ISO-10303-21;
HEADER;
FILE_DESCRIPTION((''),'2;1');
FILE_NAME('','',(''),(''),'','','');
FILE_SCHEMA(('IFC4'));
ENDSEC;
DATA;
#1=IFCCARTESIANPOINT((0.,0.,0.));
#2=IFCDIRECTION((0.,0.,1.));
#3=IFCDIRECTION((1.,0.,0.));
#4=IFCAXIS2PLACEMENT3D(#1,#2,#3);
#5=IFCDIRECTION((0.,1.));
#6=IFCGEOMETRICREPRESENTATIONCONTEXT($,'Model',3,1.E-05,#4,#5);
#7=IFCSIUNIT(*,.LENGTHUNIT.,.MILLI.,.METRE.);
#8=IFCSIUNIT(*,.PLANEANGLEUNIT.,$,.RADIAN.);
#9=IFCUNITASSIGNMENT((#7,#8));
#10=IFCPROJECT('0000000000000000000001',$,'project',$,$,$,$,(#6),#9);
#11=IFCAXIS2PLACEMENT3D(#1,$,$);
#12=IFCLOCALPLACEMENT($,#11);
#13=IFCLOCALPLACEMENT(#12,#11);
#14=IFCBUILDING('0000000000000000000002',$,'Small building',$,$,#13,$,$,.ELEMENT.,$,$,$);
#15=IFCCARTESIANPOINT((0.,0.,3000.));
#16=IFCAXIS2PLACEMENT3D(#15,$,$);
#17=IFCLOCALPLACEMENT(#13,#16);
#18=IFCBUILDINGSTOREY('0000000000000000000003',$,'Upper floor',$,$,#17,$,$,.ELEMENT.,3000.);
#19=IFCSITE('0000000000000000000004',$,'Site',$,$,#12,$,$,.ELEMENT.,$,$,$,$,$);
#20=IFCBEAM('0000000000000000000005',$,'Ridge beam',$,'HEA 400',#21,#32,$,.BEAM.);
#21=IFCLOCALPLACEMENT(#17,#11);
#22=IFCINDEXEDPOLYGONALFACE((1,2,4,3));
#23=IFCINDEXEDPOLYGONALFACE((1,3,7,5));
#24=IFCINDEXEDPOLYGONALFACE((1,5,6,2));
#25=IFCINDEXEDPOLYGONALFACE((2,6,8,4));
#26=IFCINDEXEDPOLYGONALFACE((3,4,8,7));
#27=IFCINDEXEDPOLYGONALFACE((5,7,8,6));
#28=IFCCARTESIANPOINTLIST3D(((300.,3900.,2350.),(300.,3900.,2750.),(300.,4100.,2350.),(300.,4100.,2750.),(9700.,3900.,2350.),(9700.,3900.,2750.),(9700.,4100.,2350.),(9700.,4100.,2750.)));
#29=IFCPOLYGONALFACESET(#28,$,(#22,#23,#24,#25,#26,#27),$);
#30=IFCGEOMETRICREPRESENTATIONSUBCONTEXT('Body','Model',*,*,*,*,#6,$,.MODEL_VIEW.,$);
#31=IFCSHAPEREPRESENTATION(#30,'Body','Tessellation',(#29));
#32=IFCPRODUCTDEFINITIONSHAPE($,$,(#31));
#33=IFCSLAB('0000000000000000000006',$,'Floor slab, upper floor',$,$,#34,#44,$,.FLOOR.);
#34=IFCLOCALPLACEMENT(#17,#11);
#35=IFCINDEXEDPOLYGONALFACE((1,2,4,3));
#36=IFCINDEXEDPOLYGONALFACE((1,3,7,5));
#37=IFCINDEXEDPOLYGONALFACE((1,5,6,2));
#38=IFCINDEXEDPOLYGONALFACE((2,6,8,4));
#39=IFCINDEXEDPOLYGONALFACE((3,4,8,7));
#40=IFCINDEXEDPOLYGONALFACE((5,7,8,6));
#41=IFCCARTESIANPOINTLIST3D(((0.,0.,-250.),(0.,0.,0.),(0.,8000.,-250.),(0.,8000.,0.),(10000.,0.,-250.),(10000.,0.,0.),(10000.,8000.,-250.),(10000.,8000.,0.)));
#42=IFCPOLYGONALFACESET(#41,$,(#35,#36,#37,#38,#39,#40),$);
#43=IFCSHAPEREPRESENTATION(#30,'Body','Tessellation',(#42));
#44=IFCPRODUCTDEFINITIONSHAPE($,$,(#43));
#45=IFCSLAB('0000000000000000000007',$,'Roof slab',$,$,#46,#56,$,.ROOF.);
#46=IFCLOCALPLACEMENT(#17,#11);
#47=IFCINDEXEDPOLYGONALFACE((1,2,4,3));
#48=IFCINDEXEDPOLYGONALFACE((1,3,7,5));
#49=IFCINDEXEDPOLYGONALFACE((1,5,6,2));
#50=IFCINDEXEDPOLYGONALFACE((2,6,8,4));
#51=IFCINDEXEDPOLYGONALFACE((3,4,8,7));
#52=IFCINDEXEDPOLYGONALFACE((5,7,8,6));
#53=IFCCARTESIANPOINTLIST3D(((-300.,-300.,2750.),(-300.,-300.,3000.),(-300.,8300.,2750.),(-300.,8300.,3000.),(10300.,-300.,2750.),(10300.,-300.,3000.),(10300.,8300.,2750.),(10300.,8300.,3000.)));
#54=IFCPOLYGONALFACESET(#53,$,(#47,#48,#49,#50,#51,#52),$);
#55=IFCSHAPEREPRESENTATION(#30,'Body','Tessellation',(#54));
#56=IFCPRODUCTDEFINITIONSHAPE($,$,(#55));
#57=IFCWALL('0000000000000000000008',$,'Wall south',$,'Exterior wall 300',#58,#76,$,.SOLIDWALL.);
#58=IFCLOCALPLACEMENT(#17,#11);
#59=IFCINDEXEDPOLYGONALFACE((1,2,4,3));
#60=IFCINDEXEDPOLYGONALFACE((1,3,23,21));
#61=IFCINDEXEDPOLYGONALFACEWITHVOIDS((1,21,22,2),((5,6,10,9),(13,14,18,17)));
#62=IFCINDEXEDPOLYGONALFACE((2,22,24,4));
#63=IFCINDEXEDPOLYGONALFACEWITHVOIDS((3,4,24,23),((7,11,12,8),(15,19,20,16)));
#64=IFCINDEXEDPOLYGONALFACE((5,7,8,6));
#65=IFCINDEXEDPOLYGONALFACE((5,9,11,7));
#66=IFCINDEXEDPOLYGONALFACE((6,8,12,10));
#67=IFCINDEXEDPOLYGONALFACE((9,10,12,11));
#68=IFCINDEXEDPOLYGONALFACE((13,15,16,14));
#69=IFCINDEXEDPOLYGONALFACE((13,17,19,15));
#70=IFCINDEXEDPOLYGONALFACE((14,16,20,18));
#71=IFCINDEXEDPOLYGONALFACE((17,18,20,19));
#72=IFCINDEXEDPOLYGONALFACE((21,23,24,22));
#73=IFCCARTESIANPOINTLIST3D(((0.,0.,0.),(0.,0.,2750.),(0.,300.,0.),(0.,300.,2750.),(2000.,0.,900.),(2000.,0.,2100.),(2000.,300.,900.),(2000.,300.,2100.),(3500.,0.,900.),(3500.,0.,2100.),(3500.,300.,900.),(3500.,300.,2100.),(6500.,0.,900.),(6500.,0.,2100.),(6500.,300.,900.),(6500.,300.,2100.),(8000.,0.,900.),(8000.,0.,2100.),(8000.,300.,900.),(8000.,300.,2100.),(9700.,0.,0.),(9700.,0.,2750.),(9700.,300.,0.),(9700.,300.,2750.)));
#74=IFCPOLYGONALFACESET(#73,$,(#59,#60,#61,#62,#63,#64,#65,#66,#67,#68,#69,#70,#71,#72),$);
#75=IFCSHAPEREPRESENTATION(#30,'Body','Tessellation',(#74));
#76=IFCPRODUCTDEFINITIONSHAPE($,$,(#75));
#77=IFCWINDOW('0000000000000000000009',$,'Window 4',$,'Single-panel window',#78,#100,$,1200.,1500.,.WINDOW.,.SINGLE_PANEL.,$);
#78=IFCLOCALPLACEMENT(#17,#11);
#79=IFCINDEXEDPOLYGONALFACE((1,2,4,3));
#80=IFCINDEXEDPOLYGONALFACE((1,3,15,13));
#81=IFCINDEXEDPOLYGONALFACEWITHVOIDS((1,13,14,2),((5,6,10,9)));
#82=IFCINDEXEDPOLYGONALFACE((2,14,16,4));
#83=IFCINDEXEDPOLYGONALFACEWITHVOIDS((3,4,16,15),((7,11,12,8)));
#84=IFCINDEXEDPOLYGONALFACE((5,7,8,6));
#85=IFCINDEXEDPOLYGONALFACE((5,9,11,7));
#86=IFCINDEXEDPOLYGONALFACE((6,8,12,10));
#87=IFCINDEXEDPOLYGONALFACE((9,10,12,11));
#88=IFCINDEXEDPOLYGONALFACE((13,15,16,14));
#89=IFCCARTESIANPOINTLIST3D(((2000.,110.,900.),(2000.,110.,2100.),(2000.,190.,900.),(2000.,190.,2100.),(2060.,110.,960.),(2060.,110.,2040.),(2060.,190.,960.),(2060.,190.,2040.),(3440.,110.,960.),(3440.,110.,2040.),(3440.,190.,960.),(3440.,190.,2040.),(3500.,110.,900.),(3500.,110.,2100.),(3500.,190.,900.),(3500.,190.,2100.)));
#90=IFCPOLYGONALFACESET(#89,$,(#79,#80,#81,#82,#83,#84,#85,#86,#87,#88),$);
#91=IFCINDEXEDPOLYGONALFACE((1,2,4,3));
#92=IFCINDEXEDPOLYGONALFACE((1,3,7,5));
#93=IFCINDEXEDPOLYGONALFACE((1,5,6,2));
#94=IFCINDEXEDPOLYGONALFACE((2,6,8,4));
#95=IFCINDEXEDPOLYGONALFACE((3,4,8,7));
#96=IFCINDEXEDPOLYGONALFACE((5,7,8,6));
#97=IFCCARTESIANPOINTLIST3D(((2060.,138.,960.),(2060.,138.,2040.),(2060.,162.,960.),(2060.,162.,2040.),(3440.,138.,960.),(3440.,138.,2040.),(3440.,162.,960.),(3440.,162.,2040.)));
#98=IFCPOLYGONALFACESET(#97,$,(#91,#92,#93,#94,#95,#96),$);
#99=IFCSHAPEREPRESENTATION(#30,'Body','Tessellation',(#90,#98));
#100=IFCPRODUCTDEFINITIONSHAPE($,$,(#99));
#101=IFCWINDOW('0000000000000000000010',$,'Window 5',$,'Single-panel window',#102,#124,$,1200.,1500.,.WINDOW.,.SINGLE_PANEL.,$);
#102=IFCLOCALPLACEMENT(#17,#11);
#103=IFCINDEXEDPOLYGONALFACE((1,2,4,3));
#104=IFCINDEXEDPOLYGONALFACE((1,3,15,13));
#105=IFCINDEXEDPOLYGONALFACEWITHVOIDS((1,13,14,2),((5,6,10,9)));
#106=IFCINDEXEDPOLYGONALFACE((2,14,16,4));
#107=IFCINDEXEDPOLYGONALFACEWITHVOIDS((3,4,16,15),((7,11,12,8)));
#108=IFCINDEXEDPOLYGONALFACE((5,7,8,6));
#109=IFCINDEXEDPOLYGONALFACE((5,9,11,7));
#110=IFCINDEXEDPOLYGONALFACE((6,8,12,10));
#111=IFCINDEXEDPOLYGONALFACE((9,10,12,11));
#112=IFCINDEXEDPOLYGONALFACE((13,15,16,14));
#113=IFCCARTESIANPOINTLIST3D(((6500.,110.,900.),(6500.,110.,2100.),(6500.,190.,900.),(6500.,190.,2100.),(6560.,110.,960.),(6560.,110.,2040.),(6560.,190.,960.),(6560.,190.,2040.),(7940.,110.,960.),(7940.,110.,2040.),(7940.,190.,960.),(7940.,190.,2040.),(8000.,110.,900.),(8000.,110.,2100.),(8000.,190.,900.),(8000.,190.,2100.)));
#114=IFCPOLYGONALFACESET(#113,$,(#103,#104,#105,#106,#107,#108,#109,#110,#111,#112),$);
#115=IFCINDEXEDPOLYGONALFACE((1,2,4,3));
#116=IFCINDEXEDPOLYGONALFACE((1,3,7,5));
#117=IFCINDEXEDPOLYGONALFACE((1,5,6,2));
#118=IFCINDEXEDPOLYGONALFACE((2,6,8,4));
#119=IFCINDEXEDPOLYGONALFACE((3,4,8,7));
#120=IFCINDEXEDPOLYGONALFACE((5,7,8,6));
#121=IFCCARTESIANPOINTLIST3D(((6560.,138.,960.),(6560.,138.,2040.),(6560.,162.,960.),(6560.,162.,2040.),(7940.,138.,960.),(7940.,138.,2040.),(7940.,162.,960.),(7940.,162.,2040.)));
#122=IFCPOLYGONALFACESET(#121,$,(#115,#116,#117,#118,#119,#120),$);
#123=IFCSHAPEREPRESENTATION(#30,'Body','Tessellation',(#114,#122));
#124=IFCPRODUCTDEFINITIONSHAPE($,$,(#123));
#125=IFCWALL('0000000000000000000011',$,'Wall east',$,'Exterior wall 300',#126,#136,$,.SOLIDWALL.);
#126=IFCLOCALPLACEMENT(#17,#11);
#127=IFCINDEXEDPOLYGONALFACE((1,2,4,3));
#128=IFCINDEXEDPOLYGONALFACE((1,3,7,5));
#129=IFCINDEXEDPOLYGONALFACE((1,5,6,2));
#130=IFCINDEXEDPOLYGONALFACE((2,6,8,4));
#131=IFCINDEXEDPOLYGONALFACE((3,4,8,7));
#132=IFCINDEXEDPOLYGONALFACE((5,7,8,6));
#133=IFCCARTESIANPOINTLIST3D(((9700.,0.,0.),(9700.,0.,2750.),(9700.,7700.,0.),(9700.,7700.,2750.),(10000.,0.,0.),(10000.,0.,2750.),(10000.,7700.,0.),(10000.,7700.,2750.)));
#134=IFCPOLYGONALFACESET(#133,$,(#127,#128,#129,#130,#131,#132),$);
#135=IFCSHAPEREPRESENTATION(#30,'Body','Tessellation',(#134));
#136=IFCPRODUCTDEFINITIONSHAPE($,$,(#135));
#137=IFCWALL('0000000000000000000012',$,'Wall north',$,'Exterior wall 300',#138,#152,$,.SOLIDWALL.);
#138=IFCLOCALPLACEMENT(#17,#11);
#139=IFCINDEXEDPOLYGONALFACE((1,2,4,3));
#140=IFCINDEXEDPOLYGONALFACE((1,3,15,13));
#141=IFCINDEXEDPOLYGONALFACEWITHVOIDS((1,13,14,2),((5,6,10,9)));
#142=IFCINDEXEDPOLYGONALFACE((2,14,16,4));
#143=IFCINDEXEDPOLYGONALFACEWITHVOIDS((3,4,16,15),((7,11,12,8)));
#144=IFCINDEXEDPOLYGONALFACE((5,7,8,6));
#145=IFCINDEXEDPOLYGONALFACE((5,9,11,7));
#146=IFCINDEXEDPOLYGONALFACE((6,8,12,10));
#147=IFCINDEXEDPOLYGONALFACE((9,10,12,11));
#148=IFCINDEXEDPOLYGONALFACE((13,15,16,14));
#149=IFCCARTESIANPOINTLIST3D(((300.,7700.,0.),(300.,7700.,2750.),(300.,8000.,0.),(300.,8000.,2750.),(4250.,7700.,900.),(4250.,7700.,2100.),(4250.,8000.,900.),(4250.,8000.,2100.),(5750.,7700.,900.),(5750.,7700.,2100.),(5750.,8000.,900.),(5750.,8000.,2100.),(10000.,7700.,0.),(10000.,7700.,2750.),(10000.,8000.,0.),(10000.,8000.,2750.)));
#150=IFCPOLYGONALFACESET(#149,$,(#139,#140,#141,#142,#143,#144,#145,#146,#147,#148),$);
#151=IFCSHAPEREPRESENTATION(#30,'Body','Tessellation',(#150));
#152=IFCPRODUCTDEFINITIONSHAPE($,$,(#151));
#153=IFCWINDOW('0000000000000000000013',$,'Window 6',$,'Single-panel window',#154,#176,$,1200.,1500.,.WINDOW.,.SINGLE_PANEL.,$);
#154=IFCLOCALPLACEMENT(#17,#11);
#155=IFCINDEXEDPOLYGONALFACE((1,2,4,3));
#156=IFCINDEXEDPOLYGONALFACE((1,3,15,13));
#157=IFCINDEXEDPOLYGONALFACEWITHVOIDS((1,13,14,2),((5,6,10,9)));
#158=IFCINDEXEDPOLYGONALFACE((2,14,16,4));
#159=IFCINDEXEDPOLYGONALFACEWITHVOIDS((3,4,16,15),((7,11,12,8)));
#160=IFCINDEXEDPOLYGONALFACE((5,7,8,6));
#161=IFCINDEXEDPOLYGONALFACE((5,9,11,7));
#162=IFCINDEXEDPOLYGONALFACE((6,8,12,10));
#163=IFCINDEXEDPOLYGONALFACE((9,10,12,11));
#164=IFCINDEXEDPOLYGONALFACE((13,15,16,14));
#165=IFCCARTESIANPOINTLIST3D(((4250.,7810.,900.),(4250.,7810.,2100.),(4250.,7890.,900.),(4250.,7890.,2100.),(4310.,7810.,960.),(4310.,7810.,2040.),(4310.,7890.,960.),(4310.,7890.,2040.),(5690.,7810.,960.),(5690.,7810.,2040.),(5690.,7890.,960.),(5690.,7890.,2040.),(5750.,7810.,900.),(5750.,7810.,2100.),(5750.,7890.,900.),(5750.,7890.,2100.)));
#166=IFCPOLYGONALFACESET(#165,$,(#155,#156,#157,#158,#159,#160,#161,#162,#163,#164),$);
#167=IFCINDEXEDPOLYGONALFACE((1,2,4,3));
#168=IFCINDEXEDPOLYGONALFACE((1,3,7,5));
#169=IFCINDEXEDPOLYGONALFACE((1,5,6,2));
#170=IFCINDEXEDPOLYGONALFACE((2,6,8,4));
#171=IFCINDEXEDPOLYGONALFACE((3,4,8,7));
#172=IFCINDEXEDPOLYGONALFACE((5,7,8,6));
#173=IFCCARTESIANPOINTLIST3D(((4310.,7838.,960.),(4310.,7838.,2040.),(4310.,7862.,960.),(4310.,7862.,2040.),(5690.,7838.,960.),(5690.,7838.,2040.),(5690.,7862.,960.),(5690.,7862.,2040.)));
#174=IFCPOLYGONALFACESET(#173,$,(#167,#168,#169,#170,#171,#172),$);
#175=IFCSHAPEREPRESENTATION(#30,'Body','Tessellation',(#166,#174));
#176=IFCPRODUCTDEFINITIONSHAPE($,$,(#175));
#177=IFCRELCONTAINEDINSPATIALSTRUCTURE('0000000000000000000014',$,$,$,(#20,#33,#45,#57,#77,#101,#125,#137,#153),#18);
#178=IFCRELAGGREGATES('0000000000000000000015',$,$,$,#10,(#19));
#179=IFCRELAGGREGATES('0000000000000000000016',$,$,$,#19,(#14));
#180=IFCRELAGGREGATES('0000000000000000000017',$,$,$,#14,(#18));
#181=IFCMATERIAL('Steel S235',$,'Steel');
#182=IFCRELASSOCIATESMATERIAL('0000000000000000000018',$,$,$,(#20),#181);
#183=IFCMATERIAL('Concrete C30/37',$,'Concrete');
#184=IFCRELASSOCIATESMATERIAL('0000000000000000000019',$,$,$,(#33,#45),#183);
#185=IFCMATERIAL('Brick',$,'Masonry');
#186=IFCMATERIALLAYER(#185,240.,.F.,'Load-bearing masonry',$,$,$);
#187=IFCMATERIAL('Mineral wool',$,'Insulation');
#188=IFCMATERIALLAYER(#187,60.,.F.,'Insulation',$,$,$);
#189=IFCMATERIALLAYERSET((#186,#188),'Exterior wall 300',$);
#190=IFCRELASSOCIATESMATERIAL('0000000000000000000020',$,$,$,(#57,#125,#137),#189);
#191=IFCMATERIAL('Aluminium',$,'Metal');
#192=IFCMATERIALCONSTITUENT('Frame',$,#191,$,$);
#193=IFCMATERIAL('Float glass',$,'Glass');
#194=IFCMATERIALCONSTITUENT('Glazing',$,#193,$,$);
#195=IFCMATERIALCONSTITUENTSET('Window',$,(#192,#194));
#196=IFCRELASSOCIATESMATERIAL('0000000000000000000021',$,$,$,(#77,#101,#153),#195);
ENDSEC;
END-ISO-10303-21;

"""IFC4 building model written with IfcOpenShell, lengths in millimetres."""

from ifc_helpers import new_model, si_unit, direction, frame, frame_2d, origin, origin_with_axes, origin_2d, place, context, subcontext, project, spatial, rectangle, hollow_rectangle, extrude, material, layer, layer_set, layer_usage, constituent, constituent_set, element, fill, save


model = new_model("IFC4")

# Units and contexts
model_context = context("Model", 3, precision=1e-05, world=origin_with_axes(), true_north=direction((0.0, 1.0)))
body_context = subcontext(model_context, "Body", "Model", "MODEL_VIEW")
ifc_project = project(units=[si_unit("LENGTHUNIT", "METRE", prefix="MILLI"), si_unit("PLANEANGLEUNIT", "RADIAN")], contexts=[model_context])

# Site, building, storey
site_placement = place(None, origin())
site = spatial("IfcSite", under=ifc_project, at=site_placement, Name="Site", CompositionType="ELEMENT")
building_placement = place(site_placement, origin())
building = spatial("IfcBuilding", under=site, at=building_placement, Name="Small building", CompositionType="ELEMENT")
storey_placement = place(building_placement, frame((0.0, 0.0, 3000.0)))
storey = spatial("IfcBuildingStorey", under=building, at=storey_placement, Name="Upper floor", CompositionType="ELEMENT", Elevation=3000.0)

# Beam
ifc_material_1 = material(Name="Steel S235", Category="Steel")
beam_placement = place(storey_placement, frame((300.0, 4000.0, 0.0)))
element("IfcBeam", 1, at=beam_placement, inside=storey, material=ifc_material_1, Name="Ridge beam", ObjectType="HEA 400", PredefinedType="BEAM", context=body_context, shape_type="SweptSolid", body=[
    extrude(rectangle(XDim=200.0, YDim=400.0, at=frame_2d((0.0, 2550.0))), frame((0.0, 0.0, 0.0), z_axis=(1.0, 0.0, 0.0), x_axis=(0.0, 1.0, 0.0)), (0.0, 0.0, 1.0), 9400.0),
])

# Slabs
ifc_material_2 = material(Name="Concrete C30/37", Category="Concrete")
slab_1_placement = place(storey_placement, frame((0.0, 0.0, -250.0)))
element("IfcSlab", 2, at=slab_1_placement, inside=storey, material=ifc_material_2, Name="Floor slab, upper floor", PredefinedType="FLOOR", context=body_context, shape_type="SweptSolid", body=[
    extrude(rectangle(XDim=10000.0, YDim=8000.0, at=frame_2d((5000.0, 4000.0))), origin_with_axes(), (0.0, 0.0, 1.0), 250.0),
])
slab_2_placement = place(storey_placement, frame((0.0, 0.0, 2750.0)))
element("IfcSlab", 3, at=slab_2_placement, inside=storey, material=ifc_material_2, Name="Roof slab", PredefinedType="ROOF", context=body_context, shape_type="SweptSolid", body=[
    extrude(rectangle(XDim=10600.0, YDim=8600.0, at=frame_2d((5000.0, 4000.0))), origin_with_axes(), (0.0, 0.0, 1.0), 250.0),
])

# Wall, openings, windows
ifc_material_3 = material(Name="Brick", Category="Masonry")
ifc_layer_1 = layer(ifc_material_3, 240.0, ventilated=False, Name="Load-bearing masonry")
ifc_material_4 = material(Name="Mineral wool", Category="Insulation")
ifc_layer_2 = layer(ifc_material_4, 60.0, ventilated=False, Name="Insulation")
ifc_layer_set = layer_set([ifc_layer_1, ifc_layer_2], Name="Exterior wall 300")
ifc_layer_usage_1 = layer_usage(ifc_layer_set, "AXIS2", "POSITIVE", 0.0)
wall_1_placement = place(storey_placement, frame((0.0, 0.0, 0.0), x_axis=(1.0, 0.0, 0.0)))
wall_1 = element("IfcWall", 4, at=wall_1_placement, inside=storey, material=ifc_layer_usage_1, Name="Wall south", ObjectType="Exterior wall 300", PredefinedType="SOLIDWALL", context=body_context, shape_type="SweptSolid", body=[
    extrude(rectangle(XDim=9700.0, YDim=300.0, at=frame_2d((4850.0, 150.0))), origin_with_axes(), (0.0, 0.0, 1.0), 2750.0),
])
opening_1_placement = place(wall_1_placement, frame((2000.0, 0.0, 900.0)))
opening_1 = element("IfcOpeningElement", 5, at=opening_1_placement, cuts=wall_1, PredefinedType="OPENING", context=body_context, shape_type="SweptSolid", body=[
    extrude(rectangle(XDim=1500.0, YDim=400.0, at=frame_2d((750.0, 150.0))), origin_with_axes(), (0.0, 0.0, 1.0), 1200.0),
])
opening_2_placement = place(wall_1_placement, frame((6500.0, 0.0, 900.0)))
opening_2 = element("IfcOpeningElement", 6, at=opening_2_placement, cuts=wall_1, PredefinedType="OPENING", context=body_context, shape_type="SweptSolid", body=[
    extrude(rectangle(XDim=1500.0, YDim=400.0, at=frame_2d((750.0, 150.0))), origin_with_axes(), (0.0, 0.0, 1.0), 1200.0),
])
ifc_material_5 = material(Name="Aluminium", Category="Metal")
ifc_constituent_1 = constituent(ifc_material_5, Name="Frame")
ifc_material_6 = material(Name="Float glass", Category="Glass")
ifc_constituent_2 = constituent(ifc_material_6, Name="Glazing")
ifc_constituent_set = constituent_set(constituents=[ifc_constituent_1, ifc_constituent_2], Name="Window")
window_1_placement = place(opening_1_placement, origin())
window_1 = element("IfcWindow", 7, at=window_1_placement, inside=storey, material=ifc_constituent_set, Name="Window 4", ObjectType="Single-panel window", OverallHeight=1200.0, OverallWidth=1500.0, PartitioningType="SINGLE_PANEL", PredefinedType="WINDOW", context=body_context, shape_type="SweptSolid", body=[
    extrude(hollow_rectangle(XDim=1500.0, YDim=1200.0, WallThickness=60.0, at=origin_2d()), frame((750.0, 110.0, 600.0), z_axis=(0.0, 1.0, 0.0), x_axis=(1.0, 0.0, 0.0)), (0.0, 0.0, 1.0), 80.0),
    extrude(rectangle(XDim=1380.0, YDim=1080.0, at=origin_2d()), frame((750.0, 138.0, 600.0), z_axis=(0.0, 1.0, 0.0), x_axis=(1.0, 0.0, 0.0)), (0.0, 0.0, 1.0), 24.0),
])
fill(opening_1, window_1)
window_2_placement = place(opening_2_placement, origin())
window_2 = element("IfcWindow", 8, at=window_2_placement, inside=storey, material=ifc_constituent_set, Name="Window 5", ObjectType="Single-panel window", OverallHeight=1200.0, OverallWidth=1500.0, PartitioningType="SINGLE_PANEL", PredefinedType="WINDOW", context=body_context, shape_type="SweptSolid", body=[
    extrude(hollow_rectangle(XDim=1500.0, YDim=1200.0, WallThickness=60.0, at=origin_2d()), frame((750.0, 110.0, 600.0), z_axis=(0.0, 1.0, 0.0), x_axis=(1.0, 0.0, 0.0)), (0.0, 0.0, 1.0), 80.0),
    extrude(rectangle(XDim=1380.0, YDim=1080.0, at=origin_2d()), frame((750.0, 138.0, 600.0), z_axis=(0.0, 1.0, 0.0), x_axis=(1.0, 0.0, 0.0)), (0.0, 0.0, 1.0), 24.0),
])
fill(opening_2, window_2)

# Wall
ifc_layer_usage_2 = layer_usage(ifc_layer_set, "AXIS2", "POSITIVE", 0.0)
wall_2_placement = place(storey_placement, frame((10000.0, 0.0, 0.0), x_axis=(0.0, 1.0, 0.0)))
element("IfcWall", 9, at=wall_2_placement, inside=storey, material=ifc_layer_usage_2, Name="Wall east", ObjectType="Exterior wall 300", PredefinedType="SOLIDWALL", context=body_context, shape_type="SweptSolid", body=[
    extrude(rectangle(XDim=7700.0, YDim=300.0, at=frame_2d((3850.0, 150.0))), origin_with_axes(), (0.0, 0.0, 1.0), 2750.0),
])

# Wall, opening, window
ifc_layer_usage_3 = layer_usage(ifc_layer_set, "AXIS2", "POSITIVE", 0.0)
wall_3_placement = place(storey_placement, frame((10000.0, 8000.0, 0.0), x_axis=(-1.0, 0.0, 0.0)))
wall_3 = element("IfcWall", 10, at=wall_3_placement, inside=storey, material=ifc_layer_usage_3, Name="Wall north", ObjectType="Exterior wall 300", PredefinedType="SOLIDWALL", context=body_context, shape_type="SweptSolid", body=[
    extrude(rectangle(XDim=9700.0, YDim=300.0, at=frame_2d((4850.0, 150.0))), origin_with_axes(), (0.0, 0.0, 1.0), 2750.0),
])
opening_3_placement = place(wall_3_placement, frame((4250.0, 0.0, 900.0)))
opening_3 = element("IfcOpeningElement", 11, at=opening_3_placement, cuts=wall_3, PredefinedType="OPENING", context=body_context, shape_type="SweptSolid", body=[
    extrude(rectangle(XDim=1500.0, YDim=400.0, at=frame_2d((750.0, 150.0))), origin_with_axes(), (0.0, 0.0, 1.0), 1200.0),
])
window_3_placement = place(opening_3_placement, origin())
window_3 = element("IfcWindow", 12, at=window_3_placement, inside=storey, material=ifc_constituent_set, Name="Window 6", ObjectType="Single-panel window", OverallHeight=1200.0, OverallWidth=1500.0, PartitioningType="SINGLE_PANEL", PredefinedType="WINDOW", context=body_context, shape_type="SweptSolid", body=[
    extrude(hollow_rectangle(XDim=1500.0, YDim=1200.0, WallThickness=60.0, at=origin_2d()), frame((750.0, 110.0, 600.0), z_axis=(0.0, 1.0, 0.0), x_axis=(1.0, 0.0, 0.0)), (0.0, 0.0, 1.0), 80.0),
    extrude(rectangle(XDim=1380.0, YDim=1080.0, at=origin_2d()), frame((750.0, 138.0, 600.0), z_axis=(0.0, 1.0, 0.0), x_axis=(1.0, 0.0, 0.0)), (0.0, 0.0, 1.0), 24.0),
])
fill(opening_3, window_3)

save(model, "model.ifc")
